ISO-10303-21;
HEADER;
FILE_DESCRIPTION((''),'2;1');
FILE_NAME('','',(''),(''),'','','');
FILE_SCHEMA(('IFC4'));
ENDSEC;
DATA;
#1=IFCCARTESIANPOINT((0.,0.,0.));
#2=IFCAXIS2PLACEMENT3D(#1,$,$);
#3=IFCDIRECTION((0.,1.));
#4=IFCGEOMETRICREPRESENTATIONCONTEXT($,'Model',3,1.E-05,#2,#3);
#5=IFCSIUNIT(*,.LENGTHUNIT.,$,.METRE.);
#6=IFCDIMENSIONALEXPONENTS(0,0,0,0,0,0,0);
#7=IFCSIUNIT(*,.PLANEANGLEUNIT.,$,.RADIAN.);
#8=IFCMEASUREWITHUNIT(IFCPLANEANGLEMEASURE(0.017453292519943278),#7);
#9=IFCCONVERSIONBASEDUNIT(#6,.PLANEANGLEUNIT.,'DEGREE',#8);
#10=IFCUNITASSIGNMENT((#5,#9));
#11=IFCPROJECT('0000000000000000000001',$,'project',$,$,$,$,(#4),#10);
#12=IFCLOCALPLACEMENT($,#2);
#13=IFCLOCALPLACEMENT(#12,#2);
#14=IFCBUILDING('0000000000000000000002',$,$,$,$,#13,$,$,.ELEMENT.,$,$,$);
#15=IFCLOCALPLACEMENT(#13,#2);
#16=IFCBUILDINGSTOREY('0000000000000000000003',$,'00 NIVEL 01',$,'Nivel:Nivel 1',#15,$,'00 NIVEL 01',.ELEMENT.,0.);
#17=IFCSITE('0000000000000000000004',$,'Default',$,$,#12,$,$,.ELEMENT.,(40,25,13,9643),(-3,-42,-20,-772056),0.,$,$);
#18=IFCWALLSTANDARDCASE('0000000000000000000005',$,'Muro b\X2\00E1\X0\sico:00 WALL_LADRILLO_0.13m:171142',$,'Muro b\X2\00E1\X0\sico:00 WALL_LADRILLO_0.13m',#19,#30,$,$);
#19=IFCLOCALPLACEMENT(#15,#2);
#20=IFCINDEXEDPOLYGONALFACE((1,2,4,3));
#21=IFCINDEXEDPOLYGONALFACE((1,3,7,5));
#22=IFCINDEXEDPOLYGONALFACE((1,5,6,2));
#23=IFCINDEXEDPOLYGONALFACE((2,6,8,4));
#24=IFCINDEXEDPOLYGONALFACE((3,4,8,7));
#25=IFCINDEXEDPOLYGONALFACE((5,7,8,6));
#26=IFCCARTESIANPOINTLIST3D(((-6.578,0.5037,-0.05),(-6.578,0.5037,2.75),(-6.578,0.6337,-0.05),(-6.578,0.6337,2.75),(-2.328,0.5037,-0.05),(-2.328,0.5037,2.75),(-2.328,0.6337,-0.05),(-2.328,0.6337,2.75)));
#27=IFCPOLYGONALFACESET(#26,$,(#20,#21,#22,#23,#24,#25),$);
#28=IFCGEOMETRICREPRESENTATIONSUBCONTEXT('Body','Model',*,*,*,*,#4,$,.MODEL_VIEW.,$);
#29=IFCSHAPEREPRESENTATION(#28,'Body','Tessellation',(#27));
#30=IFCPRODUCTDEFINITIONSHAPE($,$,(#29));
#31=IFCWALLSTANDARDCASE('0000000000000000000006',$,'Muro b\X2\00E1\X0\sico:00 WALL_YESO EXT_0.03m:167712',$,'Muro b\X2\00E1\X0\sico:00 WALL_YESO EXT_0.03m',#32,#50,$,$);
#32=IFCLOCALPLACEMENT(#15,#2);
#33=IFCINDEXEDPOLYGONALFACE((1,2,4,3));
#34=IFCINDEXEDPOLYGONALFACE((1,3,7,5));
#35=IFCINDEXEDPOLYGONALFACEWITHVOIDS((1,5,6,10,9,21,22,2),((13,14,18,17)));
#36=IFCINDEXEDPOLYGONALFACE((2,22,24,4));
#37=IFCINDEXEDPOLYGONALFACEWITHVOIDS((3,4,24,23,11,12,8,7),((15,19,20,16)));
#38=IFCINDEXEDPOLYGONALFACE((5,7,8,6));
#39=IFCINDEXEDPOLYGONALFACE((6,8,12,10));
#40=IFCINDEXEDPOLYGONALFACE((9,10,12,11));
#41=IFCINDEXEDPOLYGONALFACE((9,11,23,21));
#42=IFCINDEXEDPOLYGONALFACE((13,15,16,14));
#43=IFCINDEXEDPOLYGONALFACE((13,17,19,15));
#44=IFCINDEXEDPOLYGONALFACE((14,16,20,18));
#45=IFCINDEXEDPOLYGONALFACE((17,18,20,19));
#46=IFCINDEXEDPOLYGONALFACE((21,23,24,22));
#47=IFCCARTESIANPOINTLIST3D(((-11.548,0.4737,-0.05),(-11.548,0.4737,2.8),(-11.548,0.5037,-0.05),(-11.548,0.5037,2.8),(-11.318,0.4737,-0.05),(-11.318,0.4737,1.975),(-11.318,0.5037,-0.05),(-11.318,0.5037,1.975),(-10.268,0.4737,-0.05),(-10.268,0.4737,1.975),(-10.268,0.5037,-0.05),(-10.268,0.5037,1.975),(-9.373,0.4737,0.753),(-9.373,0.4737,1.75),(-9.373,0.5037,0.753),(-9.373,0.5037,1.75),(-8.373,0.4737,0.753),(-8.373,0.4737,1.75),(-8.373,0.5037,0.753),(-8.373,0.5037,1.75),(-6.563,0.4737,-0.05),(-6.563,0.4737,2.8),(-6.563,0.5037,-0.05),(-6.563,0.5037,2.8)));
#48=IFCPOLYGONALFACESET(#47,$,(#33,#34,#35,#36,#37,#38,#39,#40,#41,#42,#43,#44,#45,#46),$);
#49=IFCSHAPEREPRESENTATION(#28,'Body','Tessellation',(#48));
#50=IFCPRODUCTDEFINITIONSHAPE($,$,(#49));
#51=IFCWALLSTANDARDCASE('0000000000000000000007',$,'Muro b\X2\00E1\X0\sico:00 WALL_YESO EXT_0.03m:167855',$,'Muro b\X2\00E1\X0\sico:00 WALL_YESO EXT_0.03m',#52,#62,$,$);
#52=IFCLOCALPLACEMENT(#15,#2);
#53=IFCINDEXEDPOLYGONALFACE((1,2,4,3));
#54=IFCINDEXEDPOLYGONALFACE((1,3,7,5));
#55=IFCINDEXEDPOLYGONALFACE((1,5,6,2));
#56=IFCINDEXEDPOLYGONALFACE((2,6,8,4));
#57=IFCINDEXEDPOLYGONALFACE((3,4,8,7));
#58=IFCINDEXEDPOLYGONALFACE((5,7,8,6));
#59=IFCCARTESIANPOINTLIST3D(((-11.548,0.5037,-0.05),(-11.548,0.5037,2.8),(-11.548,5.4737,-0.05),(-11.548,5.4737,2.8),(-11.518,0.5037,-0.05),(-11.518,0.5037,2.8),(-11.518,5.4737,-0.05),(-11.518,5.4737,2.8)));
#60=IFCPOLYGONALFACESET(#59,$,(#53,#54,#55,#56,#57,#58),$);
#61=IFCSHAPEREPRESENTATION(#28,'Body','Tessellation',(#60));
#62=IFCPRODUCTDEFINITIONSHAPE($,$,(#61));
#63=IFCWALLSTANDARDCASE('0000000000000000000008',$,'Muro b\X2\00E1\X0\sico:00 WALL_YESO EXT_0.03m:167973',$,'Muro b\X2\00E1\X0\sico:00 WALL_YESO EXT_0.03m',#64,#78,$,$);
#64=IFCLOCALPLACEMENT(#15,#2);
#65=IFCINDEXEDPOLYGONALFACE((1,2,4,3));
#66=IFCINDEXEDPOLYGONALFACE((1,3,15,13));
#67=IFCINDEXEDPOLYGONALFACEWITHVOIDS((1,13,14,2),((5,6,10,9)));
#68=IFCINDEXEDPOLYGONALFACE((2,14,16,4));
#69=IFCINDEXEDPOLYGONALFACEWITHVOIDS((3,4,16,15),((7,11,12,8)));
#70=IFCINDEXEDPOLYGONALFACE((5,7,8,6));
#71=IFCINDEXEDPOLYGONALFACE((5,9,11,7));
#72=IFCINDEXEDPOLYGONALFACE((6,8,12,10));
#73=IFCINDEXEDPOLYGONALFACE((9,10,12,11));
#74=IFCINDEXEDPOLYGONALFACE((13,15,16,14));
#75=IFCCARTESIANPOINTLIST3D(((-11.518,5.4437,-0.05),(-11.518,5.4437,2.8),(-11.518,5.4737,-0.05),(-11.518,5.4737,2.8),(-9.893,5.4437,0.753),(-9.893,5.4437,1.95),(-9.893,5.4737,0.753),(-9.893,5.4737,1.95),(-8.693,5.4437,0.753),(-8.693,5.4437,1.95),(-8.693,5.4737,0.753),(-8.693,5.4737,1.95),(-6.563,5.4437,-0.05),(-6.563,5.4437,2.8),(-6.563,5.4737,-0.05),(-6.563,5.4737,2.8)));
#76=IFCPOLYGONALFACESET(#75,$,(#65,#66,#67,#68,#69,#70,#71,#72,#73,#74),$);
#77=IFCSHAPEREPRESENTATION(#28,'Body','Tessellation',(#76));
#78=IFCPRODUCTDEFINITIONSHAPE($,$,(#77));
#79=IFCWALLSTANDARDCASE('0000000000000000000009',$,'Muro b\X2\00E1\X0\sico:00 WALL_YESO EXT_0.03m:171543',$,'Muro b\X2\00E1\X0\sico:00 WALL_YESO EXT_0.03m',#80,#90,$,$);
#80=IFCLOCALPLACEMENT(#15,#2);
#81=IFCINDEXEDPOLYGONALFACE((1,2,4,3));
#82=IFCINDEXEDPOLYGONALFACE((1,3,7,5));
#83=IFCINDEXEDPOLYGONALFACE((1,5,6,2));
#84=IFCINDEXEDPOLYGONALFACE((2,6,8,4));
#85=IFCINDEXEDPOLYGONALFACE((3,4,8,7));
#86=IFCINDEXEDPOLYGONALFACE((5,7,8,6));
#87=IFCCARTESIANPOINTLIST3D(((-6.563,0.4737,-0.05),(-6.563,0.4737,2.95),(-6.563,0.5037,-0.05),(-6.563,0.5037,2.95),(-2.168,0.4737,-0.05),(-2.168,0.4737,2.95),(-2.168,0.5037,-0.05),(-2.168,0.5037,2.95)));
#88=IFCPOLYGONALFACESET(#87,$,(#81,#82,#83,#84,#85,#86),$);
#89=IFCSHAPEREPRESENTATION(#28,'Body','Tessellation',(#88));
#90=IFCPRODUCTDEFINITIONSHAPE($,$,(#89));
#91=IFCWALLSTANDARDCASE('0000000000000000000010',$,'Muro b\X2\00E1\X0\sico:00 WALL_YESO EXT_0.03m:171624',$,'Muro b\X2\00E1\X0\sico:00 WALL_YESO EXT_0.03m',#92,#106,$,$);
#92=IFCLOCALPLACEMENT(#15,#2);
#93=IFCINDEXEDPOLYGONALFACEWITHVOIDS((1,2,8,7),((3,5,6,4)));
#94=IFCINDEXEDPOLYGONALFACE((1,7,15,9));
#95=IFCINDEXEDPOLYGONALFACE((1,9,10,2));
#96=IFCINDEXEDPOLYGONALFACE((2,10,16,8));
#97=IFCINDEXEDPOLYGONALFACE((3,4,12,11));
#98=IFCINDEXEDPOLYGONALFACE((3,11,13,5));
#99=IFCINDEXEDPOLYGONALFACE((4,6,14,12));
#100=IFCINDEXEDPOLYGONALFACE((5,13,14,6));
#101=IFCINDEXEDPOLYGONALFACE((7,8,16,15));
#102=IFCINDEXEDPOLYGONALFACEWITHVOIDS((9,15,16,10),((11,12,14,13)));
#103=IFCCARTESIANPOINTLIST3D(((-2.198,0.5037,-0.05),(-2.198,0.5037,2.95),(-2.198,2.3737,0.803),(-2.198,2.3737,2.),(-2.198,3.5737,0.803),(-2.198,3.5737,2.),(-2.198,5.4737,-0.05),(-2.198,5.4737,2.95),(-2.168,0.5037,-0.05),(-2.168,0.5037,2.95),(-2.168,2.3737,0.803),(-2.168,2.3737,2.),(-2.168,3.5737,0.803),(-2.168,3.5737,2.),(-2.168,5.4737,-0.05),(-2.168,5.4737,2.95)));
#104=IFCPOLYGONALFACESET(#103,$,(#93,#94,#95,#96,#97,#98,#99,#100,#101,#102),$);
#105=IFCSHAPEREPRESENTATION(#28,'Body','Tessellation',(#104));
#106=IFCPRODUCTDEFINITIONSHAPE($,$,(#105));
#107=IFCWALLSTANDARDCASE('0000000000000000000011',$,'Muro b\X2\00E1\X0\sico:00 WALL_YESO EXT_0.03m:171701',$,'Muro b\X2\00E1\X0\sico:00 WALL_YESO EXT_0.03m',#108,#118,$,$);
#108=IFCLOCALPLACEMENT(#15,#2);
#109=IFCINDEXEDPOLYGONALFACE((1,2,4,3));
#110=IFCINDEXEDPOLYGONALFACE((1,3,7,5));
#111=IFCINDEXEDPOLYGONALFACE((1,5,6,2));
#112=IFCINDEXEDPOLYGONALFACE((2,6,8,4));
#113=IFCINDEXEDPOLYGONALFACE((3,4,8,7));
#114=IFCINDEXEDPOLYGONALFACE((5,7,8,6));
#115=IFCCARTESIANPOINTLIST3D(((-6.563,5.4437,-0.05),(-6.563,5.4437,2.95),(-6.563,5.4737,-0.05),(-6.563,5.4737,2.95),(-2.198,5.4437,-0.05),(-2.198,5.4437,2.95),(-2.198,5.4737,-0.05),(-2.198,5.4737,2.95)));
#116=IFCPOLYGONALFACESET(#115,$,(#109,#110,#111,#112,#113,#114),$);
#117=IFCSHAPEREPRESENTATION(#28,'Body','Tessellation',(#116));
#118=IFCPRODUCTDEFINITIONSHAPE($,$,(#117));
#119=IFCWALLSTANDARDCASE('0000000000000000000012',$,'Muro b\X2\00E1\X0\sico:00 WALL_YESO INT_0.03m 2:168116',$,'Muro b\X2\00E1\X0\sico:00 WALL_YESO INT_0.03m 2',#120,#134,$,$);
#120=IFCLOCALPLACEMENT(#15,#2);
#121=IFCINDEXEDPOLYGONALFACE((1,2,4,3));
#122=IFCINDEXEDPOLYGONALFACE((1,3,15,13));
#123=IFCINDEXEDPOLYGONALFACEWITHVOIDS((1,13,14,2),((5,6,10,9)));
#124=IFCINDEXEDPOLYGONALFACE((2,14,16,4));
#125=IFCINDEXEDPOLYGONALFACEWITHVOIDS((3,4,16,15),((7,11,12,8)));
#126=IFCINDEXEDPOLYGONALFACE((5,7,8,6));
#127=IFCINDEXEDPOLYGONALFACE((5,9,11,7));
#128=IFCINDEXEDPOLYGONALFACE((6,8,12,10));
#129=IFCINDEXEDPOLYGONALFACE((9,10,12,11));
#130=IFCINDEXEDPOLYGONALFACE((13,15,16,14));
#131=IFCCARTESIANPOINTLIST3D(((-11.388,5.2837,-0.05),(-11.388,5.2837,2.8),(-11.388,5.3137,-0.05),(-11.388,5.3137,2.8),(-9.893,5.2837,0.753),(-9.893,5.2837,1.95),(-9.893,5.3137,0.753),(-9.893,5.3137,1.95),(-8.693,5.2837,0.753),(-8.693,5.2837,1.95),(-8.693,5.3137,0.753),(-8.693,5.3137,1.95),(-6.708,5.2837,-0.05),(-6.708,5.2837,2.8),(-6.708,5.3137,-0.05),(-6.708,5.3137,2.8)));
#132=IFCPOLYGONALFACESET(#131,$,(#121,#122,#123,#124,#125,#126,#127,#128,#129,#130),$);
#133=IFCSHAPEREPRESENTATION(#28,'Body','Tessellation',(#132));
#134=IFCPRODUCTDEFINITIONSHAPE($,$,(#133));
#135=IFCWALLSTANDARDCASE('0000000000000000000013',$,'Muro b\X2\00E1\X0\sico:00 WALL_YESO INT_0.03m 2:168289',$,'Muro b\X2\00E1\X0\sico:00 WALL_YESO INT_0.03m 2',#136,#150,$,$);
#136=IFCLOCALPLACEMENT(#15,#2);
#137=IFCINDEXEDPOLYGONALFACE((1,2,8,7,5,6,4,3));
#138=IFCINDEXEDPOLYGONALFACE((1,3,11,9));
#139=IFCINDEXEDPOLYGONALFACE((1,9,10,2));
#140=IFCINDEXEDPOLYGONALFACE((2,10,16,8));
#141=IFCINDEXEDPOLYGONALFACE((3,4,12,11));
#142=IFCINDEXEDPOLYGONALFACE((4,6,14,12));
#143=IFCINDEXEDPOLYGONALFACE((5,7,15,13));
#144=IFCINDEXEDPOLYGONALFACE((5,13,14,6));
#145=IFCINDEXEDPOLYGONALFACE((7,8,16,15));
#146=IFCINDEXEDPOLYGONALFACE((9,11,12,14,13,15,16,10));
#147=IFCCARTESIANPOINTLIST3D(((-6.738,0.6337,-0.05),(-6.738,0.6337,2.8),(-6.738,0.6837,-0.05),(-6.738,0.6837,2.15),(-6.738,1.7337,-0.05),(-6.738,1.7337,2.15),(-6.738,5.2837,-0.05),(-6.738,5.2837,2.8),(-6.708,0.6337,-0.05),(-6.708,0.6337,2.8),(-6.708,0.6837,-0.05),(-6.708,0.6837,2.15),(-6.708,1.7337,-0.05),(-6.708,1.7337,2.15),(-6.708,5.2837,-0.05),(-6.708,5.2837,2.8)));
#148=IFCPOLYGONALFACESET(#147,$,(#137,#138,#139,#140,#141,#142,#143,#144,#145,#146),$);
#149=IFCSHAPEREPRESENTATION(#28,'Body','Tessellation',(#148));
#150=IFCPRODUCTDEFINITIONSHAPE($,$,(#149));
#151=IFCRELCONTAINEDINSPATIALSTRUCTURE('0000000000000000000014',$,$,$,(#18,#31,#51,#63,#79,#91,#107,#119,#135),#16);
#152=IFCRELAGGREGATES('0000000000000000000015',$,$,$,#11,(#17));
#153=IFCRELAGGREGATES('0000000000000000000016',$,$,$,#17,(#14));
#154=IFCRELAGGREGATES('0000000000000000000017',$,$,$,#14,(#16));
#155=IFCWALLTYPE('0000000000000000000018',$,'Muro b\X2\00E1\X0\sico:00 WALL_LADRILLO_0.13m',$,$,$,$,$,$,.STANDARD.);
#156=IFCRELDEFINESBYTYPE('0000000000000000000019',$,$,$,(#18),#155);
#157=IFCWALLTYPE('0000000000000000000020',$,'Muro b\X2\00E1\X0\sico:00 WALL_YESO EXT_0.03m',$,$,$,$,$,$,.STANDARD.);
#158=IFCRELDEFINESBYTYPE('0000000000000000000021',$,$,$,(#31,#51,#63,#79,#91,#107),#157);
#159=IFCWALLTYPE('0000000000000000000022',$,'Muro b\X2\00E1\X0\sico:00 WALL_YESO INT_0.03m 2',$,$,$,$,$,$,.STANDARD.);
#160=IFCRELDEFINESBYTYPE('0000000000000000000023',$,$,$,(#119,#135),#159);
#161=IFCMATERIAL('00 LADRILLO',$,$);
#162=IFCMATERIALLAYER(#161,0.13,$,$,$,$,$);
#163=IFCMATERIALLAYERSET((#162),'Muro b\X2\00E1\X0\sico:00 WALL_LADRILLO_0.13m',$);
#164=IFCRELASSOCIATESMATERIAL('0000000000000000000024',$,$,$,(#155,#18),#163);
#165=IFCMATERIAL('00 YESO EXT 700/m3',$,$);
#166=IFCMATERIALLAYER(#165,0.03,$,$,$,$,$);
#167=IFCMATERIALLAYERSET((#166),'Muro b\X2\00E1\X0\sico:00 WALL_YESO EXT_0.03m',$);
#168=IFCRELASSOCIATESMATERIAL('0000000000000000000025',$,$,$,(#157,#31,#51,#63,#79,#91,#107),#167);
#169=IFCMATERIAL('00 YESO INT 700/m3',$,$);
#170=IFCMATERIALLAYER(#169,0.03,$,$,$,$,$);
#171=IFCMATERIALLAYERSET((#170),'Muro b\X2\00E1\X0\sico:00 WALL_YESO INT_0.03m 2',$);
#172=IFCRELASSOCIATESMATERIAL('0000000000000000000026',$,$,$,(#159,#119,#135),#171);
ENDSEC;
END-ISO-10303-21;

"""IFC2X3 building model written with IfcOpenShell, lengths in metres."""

from ifc_helpers import new_model, entity, si_unit, converted_unit, direction, frame, frame_2d, origin, place, context, subcontext, project, spatial, rectangle, extrude, material, layer, layer_set, layer_usage, type_object, element, save


model = new_model("IFC2X3")

# Units and contexts
model_context = context("Model", 3, precision=1e-05, world=origin(), true_north=direction((0.0, 1.0)))
body_context = subcontext(model_context, "Body", "Model", "MODEL_VIEW")
ifc_project = project(units=[si_unit("LENGTHUNIT", "METRE"), converted_unit("PLANEANGLEUNIT", "DEGREE", entity("IfcPlaneAngleMeasure", 0.017453292519943278), si_unit("PLANEANGLEUNIT", "RADIAN"), dimensions=[0, 0, 0, 0, 0, 0, 0])], contexts=[model_context])

# Site, building, storey
site_placement = place(None, origin())
site = spatial("IfcSite", under=ifc_project, at=site_placement, Name="Default", CompositionType="ELEMENT", RefLatitude=(40, 25, 13, 9643), RefLongitude=(-3, -42, -20, -772056), RefElevation=0.0)
building_placement = place(site_placement, origin())
building = spatial("IfcBuilding", under=site, at=building_placement, CompositionType="ELEMENT")
storey_placement = place(building_placement, origin())
storey = spatial("IfcBuildingStorey", under=building, at=storey_placement, Name="00 NIVEL 01", ObjectType="Nivel:Nivel 1", LongName="00 NIVEL 01", CompositionType="ELEMENT", Elevation=0.0)

# Shared definitions
ifc_material_1 = material(Name="00 LADRILLO")
ifc_layer_1 = layer(ifc_material_1, 0.13)
ifc_layer_set_1 = layer_set([ifc_layer_1], Name="Muro básico:00 WALL_LADRILLO_0.13m")
wall_type_1 = type_object("IfcWallType", Name="Muro básico:00 WALL_LADRILLO_0.13m", PredefinedType="STANDARD", material=ifc_layer_set_1)

# Wall
ifc_layer_usage_1 = layer_usage(ifc_layer_set_1, "AXIS2", "POSITIVE", -0.065)
wall_1_placement = place(storey_placement, frame((-6.578, 0.5687, -0.05)))
element("IfcWallStandardCase", 1, at=wall_1_placement, inside=storey, type_object=wall_type_1, material=ifc_layer_usage_1, Name="Muro básico:00 WALL_LADRILLO_0.13m:171142", ObjectType="Muro básico:00 WALL_LADRILLO_0.13m", context=body_context, shape_type="SweptSolid", body=[
    extrude(rectangle(XDim=4.25, YDim=0.13, at=frame_2d((2.125, 0.0), x_axis=(-1.0, 0.0))), origin(), (0.0, 0.0, 1.0), 2.8),
])

# Wall, openings
ifc_material_2 = material(Name="00 YESO EXT 700/m3")
ifc_layer_2 = layer(ifc_material_2, 0.03)
ifc_layer_set_2 = layer_set([ifc_layer_2], Name="Muro básico:00 WALL_YESO EXT_0.03m")
ifc_layer_usage_2 = layer_usage(ifc_layer_set_2, "AXIS2", "POSITIVE", -0.015)
wall_type_2 = type_object("IfcWallType", Name="Muro básico:00 WALL_YESO EXT_0.03m", PredefinedType="STANDARD", material=ifc_layer_set_2)
wall_2_placement = place(storey_placement, frame((-11.548, 0.4887, -0.05)))
wall_2 = element("IfcWallStandardCase", 2, at=wall_2_placement, inside=storey, type_object=wall_type_2, material=ifc_layer_usage_2, Name="Muro básico:00 WALL_YESO EXT_0.03m:167712", ObjectType="Muro básico:00 WALL_YESO EXT_0.03m", context=body_context, shape_type="SweptSolid", body=[
    extrude(rectangle(XDim=4.985, YDim=0.03, at=frame_2d((2.4925, 0.0), x_axis=(-1.0, 0.0))), origin(), (0.0, 0.0, 1.0), 2.85),
])
opening_1_placement = place(wall_2_placement, origin())
element("IfcOpeningElement", 3, at=opening_1_placement, cuts=wall_2, ObjectType="Opening", context=body_context, shape_type="SweptSolid", body=[
    extrude(rectangle(XDim=0.997, YDim=1.0, at=frame_2d((0.0, 0.0), x_axis=(0.0, 1.0))), frame((2.675, 0.015, 1.3015), z_axis=(0.0, -1.0, 0.0), x_axis=(1.0, 0.0, 0.0)), (0.0, 0.0, 1.0), 0.03),
])
opening_2_placement = place(wall_2_placement, origin())
element("IfcOpeningElement", 4, at=opening_2_placement, cuts=wall_2, ObjectType="Opening", context=body_context, shape_type="SweptSolid", body=[
    extrude(rectangle(XDim=2.025, YDim=1.05, at=frame_2d((0.0, 0.0), x_axis=(0.0, 1.0))), frame((0.755, 0.015, 1.0125), z_axis=(0.0, -1.0, 0.0), x_axis=(1.0, 0.0, 0.0)), (0.0, 0.0, 1.0), 0.03),
])

# Wall
ifc_layer_usage_3 = layer_usage(ifc_layer_set_2, "AXIS2", "NEGATIVE", 0.015)
wall_3_placement = place(storey_placement, frame((-11.533, 0.5037, -0.05), z_axis=(0.0, 0.0, 1.0), x_axis=(0.0, 1.0, 0.0)))
element("IfcWallStandardCase", 5, at=wall_3_placement, inside=storey, type_object=wall_type_2, material=ifc_layer_usage_3, Name="Muro básico:00 WALL_YESO EXT_0.03m:167855", ObjectType="Muro básico:00 WALL_YESO EXT_0.03m", context=body_context, shape_type="SweptSolid", body=[
    extrude(rectangle(XDim=4.97, YDim=0.03, at=frame_2d((2.485, 0.0), x_axis=(-1.0, 0.0))), origin(), (0.0, 0.0, 1.0), 2.85),
])

# Wall, opening
ifc_layer_usage_4 = layer_usage(ifc_layer_set_2, "AXIS2", "NEGATIVE", 0.015)
wall_4_placement = place(storey_placement, frame((-11.518, 5.4587, -0.05)))
wall_4 = element("IfcWallStandardCase", 6, at=wall_4_placement, inside=storey, type_object=wall_type_2, material=ifc_layer_usage_4, Name="Muro básico:00 WALL_YESO EXT_0.03m:167973", ObjectType="Muro básico:00 WALL_YESO EXT_0.03m", context=body_context, shape_type="SweptSolid", body=[
    extrude(rectangle(XDim=4.955, YDim=0.03, at=frame_2d((2.4775, 0.0), x_axis=(-1.0, 0.0))), origin(), (0.0, 0.0, 1.0), 2.85),
])
opening_3_placement = place(wall_4_placement, origin())
element("IfcOpeningElement", 7, at=opening_3_placement, cuts=wall_4, ObjectType="Opening", context=body_context, shape_type="SweptSolid", body=[
    extrude(rectangle(XDim=1.197, YDim=1.2, at=frame_2d((0.0, 0.0), x_axis=(1.0, 0.0))), frame((2.225, 0.015, 1.4015), z_axis=(0.0, -1.0, 0.0), x_axis=(0.0, 0.0, -1.0)), (0.0, 0.0, 1.0), 0.03),
])

# Wall
ifc_layer_usage_5 = layer_usage(ifc_layer_set_2, "AXIS2", "NEGATIVE", 0.015)
wall_5_placement = place(storey_placement, frame((-6.563, 0.4887, -0.05)))
element("IfcWallStandardCase", 8, at=wall_5_placement, inside=storey, type_object=wall_type_2, material=ifc_layer_usage_5, Name="Muro básico:00 WALL_YESO EXT_0.03m:171543", ObjectType="Muro básico:00 WALL_YESO EXT_0.03m", context=body_context, shape_type="SweptSolid", body=[
    extrude(rectangle(XDim=4.395, YDim=0.03, at=frame_2d((2.1975, 0.0), x_axis=(-1.0, 0.0))), origin(), (0.0, 0.0, 1.0), 3.0),
])

# Wall, opening
ifc_layer_usage_6 = layer_usage(ifc_layer_set_2, "AXIS2", "NEGATIVE", 0.015)
wall_6_placement = place(storey_placement, frame((-2.183, 0.5037, -0.05), z_axis=(0.0, 0.0, 1.0), x_axis=(0.0, 1.0, 0.0)))
wall_6 = element("IfcWallStandardCase", 9, at=wall_6_placement, inside=storey, type_object=wall_type_2, material=ifc_layer_usage_6, Name="Muro básico:00 WALL_YESO EXT_0.03m:171624", ObjectType="Muro básico:00 WALL_YESO EXT_0.03m", context=body_context, shape_type="SweptSolid", body=[
    extrude(rectangle(XDim=4.97, YDim=0.03, at=frame_2d((2.485, 0.0), x_axis=(-1.0, 0.0))), origin(), (0.0, 0.0, 1.0), 3.0),
])
opening_4_placement = place(wall_6_placement, origin())
element("IfcOpeningElement", 10, at=opening_4_placement, cuts=wall_6, ObjectType="Opening", context=body_context, shape_type="SweptSolid", body=[
    extrude(rectangle(XDim=1.197, YDim=1.2, at=frame_2d((0.0, 0.0), x_axis=(0.0, 1.0))), frame((2.47, 0.015, 1.4515), z_axis=(0.0, -1.0, 0.0), x_axis=(-1.0, 0.0, 0.0)), (0.0, 0.0, 1.0), 0.03),
])

# Wall
ifc_layer_usage_7 = layer_usage(ifc_layer_set_2, "AXIS2", "NEGATIVE", 0.015)
wall_7_placement = place(storey_placement, frame((-2.198, 5.4587, -0.05), z_axis=(0.0, 0.0, 1.0), x_axis=(-1.0, 0.0, 0.0)))
element("IfcWallStandardCase", 11, at=wall_7_placement, inside=storey, type_object=wall_type_2, material=ifc_layer_usage_7, Name="Muro básico:00 WALL_YESO EXT_0.03m:171701", ObjectType="Muro básico:00 WALL_YESO EXT_0.03m", context=body_context, shape_type="SweptSolid", body=[
    extrude(rectangle(XDim=4.365, YDim=0.03, at=frame_2d((2.1825, 0.0), x_axis=(-1.0, 0.0))), origin(), (0.0, 0.0, 1.0), 3.0),
])

# Walls, openings
ifc_material_3 = material(Name="00 YESO INT 700/m3")
ifc_layer_3 = layer(ifc_material_3, 0.03)
ifc_layer_set_3 = layer_set([ifc_layer_3], Name="Muro básico:00 WALL_YESO INT_0.03m 2")
ifc_layer_usage_8 = layer_usage(ifc_layer_set_3, "AXIS2", "NEGATIVE", 0.015)
wall_type_3 = type_object("IfcWallType", Name="Muro básico:00 WALL_YESO INT_0.03m 2", PredefinedType="STANDARD", material=ifc_layer_set_3)
wall_8_placement = place(storey_placement, frame((-11.388, 5.2987, -0.05)))
wall_8 = element("IfcWallStandardCase", 12, at=wall_8_placement, inside=storey, type_object=wall_type_3, material=ifc_layer_usage_8, Name="Muro básico:00 WALL_YESO INT_0.03m 2:168116", ObjectType="Muro básico:00 WALL_YESO INT_0.03m 2", context=body_context, shape_type="SweptSolid", body=[
    extrude(rectangle(XDim=4.68, YDim=0.03, at=frame_2d((2.34, 0.0), x_axis=(-1.0, 0.0))), origin(), (0.0, 0.0, 1.0), 2.85),
])
opening_5_placement = place(wall_8_placement, origin())
element("IfcOpeningElement", 13, at=opening_5_placement, cuts=wall_8, ObjectType="Opening", context=body_context, shape_type="SweptSolid", body=[
    extrude(rectangle(XDim=1.197, YDim=1.2, at=frame_2d((0.0, 0.0), x_axis=(1.0, 0.0))), frame((2.095, 0.015, 1.4015), z_axis=(0.0, -1.0, 0.0), x_axis=(0.0, 0.0, 1.0)), (0.0, 0.0, 1.0), 0.03),
])
ifc_layer_usage_9 = layer_usage(ifc_layer_set_3, "AXIS2", "NEGATIVE", 0.015)
wall_9_placement = place(storey_placement, frame((-6.723, 5.2837, -0.05), z_axis=(0.0, 0.0, 1.0), x_axis=(0.0, -1.0, 0.0)))
wall_9 = element("IfcWallStandardCase", 14, at=wall_9_placement, inside=storey, type_object=wall_type_3, material=ifc_layer_usage_9, Name="Muro básico:00 WALL_YESO INT_0.03m 2:168289", ObjectType="Muro básico:00 WALL_YESO INT_0.03m 2", context=body_context, shape_type="SweptSolid", body=[
    extrude(rectangle(XDim=4.65, YDim=0.03, at=frame_2d((2.325, 0.0), x_axis=(-1.0, 0.0))), origin(), (0.0, 0.0, 1.0), 2.85),
])
opening_6_placement = place(wall_9_placement, origin())
element("IfcOpeningElement", 15, at=opening_6_placement, cuts=wall_9, ObjectType="Opening", context=body_context, shape_type="SweptSolid", body=[
    extrude(rectangle(XDim=2.2, YDim=1.05, at=frame_2d((0.0, 0.0), x_axis=(0.0, 1.0))), frame((4.075, 0.015, 1.1), z_axis=(0.0, -1.0, 0.0), x_axis=(1.0, 0.0, 0.0)), (0.0, 0.0, 1.0), 0.03),
])

save(model, "model.ifc")
